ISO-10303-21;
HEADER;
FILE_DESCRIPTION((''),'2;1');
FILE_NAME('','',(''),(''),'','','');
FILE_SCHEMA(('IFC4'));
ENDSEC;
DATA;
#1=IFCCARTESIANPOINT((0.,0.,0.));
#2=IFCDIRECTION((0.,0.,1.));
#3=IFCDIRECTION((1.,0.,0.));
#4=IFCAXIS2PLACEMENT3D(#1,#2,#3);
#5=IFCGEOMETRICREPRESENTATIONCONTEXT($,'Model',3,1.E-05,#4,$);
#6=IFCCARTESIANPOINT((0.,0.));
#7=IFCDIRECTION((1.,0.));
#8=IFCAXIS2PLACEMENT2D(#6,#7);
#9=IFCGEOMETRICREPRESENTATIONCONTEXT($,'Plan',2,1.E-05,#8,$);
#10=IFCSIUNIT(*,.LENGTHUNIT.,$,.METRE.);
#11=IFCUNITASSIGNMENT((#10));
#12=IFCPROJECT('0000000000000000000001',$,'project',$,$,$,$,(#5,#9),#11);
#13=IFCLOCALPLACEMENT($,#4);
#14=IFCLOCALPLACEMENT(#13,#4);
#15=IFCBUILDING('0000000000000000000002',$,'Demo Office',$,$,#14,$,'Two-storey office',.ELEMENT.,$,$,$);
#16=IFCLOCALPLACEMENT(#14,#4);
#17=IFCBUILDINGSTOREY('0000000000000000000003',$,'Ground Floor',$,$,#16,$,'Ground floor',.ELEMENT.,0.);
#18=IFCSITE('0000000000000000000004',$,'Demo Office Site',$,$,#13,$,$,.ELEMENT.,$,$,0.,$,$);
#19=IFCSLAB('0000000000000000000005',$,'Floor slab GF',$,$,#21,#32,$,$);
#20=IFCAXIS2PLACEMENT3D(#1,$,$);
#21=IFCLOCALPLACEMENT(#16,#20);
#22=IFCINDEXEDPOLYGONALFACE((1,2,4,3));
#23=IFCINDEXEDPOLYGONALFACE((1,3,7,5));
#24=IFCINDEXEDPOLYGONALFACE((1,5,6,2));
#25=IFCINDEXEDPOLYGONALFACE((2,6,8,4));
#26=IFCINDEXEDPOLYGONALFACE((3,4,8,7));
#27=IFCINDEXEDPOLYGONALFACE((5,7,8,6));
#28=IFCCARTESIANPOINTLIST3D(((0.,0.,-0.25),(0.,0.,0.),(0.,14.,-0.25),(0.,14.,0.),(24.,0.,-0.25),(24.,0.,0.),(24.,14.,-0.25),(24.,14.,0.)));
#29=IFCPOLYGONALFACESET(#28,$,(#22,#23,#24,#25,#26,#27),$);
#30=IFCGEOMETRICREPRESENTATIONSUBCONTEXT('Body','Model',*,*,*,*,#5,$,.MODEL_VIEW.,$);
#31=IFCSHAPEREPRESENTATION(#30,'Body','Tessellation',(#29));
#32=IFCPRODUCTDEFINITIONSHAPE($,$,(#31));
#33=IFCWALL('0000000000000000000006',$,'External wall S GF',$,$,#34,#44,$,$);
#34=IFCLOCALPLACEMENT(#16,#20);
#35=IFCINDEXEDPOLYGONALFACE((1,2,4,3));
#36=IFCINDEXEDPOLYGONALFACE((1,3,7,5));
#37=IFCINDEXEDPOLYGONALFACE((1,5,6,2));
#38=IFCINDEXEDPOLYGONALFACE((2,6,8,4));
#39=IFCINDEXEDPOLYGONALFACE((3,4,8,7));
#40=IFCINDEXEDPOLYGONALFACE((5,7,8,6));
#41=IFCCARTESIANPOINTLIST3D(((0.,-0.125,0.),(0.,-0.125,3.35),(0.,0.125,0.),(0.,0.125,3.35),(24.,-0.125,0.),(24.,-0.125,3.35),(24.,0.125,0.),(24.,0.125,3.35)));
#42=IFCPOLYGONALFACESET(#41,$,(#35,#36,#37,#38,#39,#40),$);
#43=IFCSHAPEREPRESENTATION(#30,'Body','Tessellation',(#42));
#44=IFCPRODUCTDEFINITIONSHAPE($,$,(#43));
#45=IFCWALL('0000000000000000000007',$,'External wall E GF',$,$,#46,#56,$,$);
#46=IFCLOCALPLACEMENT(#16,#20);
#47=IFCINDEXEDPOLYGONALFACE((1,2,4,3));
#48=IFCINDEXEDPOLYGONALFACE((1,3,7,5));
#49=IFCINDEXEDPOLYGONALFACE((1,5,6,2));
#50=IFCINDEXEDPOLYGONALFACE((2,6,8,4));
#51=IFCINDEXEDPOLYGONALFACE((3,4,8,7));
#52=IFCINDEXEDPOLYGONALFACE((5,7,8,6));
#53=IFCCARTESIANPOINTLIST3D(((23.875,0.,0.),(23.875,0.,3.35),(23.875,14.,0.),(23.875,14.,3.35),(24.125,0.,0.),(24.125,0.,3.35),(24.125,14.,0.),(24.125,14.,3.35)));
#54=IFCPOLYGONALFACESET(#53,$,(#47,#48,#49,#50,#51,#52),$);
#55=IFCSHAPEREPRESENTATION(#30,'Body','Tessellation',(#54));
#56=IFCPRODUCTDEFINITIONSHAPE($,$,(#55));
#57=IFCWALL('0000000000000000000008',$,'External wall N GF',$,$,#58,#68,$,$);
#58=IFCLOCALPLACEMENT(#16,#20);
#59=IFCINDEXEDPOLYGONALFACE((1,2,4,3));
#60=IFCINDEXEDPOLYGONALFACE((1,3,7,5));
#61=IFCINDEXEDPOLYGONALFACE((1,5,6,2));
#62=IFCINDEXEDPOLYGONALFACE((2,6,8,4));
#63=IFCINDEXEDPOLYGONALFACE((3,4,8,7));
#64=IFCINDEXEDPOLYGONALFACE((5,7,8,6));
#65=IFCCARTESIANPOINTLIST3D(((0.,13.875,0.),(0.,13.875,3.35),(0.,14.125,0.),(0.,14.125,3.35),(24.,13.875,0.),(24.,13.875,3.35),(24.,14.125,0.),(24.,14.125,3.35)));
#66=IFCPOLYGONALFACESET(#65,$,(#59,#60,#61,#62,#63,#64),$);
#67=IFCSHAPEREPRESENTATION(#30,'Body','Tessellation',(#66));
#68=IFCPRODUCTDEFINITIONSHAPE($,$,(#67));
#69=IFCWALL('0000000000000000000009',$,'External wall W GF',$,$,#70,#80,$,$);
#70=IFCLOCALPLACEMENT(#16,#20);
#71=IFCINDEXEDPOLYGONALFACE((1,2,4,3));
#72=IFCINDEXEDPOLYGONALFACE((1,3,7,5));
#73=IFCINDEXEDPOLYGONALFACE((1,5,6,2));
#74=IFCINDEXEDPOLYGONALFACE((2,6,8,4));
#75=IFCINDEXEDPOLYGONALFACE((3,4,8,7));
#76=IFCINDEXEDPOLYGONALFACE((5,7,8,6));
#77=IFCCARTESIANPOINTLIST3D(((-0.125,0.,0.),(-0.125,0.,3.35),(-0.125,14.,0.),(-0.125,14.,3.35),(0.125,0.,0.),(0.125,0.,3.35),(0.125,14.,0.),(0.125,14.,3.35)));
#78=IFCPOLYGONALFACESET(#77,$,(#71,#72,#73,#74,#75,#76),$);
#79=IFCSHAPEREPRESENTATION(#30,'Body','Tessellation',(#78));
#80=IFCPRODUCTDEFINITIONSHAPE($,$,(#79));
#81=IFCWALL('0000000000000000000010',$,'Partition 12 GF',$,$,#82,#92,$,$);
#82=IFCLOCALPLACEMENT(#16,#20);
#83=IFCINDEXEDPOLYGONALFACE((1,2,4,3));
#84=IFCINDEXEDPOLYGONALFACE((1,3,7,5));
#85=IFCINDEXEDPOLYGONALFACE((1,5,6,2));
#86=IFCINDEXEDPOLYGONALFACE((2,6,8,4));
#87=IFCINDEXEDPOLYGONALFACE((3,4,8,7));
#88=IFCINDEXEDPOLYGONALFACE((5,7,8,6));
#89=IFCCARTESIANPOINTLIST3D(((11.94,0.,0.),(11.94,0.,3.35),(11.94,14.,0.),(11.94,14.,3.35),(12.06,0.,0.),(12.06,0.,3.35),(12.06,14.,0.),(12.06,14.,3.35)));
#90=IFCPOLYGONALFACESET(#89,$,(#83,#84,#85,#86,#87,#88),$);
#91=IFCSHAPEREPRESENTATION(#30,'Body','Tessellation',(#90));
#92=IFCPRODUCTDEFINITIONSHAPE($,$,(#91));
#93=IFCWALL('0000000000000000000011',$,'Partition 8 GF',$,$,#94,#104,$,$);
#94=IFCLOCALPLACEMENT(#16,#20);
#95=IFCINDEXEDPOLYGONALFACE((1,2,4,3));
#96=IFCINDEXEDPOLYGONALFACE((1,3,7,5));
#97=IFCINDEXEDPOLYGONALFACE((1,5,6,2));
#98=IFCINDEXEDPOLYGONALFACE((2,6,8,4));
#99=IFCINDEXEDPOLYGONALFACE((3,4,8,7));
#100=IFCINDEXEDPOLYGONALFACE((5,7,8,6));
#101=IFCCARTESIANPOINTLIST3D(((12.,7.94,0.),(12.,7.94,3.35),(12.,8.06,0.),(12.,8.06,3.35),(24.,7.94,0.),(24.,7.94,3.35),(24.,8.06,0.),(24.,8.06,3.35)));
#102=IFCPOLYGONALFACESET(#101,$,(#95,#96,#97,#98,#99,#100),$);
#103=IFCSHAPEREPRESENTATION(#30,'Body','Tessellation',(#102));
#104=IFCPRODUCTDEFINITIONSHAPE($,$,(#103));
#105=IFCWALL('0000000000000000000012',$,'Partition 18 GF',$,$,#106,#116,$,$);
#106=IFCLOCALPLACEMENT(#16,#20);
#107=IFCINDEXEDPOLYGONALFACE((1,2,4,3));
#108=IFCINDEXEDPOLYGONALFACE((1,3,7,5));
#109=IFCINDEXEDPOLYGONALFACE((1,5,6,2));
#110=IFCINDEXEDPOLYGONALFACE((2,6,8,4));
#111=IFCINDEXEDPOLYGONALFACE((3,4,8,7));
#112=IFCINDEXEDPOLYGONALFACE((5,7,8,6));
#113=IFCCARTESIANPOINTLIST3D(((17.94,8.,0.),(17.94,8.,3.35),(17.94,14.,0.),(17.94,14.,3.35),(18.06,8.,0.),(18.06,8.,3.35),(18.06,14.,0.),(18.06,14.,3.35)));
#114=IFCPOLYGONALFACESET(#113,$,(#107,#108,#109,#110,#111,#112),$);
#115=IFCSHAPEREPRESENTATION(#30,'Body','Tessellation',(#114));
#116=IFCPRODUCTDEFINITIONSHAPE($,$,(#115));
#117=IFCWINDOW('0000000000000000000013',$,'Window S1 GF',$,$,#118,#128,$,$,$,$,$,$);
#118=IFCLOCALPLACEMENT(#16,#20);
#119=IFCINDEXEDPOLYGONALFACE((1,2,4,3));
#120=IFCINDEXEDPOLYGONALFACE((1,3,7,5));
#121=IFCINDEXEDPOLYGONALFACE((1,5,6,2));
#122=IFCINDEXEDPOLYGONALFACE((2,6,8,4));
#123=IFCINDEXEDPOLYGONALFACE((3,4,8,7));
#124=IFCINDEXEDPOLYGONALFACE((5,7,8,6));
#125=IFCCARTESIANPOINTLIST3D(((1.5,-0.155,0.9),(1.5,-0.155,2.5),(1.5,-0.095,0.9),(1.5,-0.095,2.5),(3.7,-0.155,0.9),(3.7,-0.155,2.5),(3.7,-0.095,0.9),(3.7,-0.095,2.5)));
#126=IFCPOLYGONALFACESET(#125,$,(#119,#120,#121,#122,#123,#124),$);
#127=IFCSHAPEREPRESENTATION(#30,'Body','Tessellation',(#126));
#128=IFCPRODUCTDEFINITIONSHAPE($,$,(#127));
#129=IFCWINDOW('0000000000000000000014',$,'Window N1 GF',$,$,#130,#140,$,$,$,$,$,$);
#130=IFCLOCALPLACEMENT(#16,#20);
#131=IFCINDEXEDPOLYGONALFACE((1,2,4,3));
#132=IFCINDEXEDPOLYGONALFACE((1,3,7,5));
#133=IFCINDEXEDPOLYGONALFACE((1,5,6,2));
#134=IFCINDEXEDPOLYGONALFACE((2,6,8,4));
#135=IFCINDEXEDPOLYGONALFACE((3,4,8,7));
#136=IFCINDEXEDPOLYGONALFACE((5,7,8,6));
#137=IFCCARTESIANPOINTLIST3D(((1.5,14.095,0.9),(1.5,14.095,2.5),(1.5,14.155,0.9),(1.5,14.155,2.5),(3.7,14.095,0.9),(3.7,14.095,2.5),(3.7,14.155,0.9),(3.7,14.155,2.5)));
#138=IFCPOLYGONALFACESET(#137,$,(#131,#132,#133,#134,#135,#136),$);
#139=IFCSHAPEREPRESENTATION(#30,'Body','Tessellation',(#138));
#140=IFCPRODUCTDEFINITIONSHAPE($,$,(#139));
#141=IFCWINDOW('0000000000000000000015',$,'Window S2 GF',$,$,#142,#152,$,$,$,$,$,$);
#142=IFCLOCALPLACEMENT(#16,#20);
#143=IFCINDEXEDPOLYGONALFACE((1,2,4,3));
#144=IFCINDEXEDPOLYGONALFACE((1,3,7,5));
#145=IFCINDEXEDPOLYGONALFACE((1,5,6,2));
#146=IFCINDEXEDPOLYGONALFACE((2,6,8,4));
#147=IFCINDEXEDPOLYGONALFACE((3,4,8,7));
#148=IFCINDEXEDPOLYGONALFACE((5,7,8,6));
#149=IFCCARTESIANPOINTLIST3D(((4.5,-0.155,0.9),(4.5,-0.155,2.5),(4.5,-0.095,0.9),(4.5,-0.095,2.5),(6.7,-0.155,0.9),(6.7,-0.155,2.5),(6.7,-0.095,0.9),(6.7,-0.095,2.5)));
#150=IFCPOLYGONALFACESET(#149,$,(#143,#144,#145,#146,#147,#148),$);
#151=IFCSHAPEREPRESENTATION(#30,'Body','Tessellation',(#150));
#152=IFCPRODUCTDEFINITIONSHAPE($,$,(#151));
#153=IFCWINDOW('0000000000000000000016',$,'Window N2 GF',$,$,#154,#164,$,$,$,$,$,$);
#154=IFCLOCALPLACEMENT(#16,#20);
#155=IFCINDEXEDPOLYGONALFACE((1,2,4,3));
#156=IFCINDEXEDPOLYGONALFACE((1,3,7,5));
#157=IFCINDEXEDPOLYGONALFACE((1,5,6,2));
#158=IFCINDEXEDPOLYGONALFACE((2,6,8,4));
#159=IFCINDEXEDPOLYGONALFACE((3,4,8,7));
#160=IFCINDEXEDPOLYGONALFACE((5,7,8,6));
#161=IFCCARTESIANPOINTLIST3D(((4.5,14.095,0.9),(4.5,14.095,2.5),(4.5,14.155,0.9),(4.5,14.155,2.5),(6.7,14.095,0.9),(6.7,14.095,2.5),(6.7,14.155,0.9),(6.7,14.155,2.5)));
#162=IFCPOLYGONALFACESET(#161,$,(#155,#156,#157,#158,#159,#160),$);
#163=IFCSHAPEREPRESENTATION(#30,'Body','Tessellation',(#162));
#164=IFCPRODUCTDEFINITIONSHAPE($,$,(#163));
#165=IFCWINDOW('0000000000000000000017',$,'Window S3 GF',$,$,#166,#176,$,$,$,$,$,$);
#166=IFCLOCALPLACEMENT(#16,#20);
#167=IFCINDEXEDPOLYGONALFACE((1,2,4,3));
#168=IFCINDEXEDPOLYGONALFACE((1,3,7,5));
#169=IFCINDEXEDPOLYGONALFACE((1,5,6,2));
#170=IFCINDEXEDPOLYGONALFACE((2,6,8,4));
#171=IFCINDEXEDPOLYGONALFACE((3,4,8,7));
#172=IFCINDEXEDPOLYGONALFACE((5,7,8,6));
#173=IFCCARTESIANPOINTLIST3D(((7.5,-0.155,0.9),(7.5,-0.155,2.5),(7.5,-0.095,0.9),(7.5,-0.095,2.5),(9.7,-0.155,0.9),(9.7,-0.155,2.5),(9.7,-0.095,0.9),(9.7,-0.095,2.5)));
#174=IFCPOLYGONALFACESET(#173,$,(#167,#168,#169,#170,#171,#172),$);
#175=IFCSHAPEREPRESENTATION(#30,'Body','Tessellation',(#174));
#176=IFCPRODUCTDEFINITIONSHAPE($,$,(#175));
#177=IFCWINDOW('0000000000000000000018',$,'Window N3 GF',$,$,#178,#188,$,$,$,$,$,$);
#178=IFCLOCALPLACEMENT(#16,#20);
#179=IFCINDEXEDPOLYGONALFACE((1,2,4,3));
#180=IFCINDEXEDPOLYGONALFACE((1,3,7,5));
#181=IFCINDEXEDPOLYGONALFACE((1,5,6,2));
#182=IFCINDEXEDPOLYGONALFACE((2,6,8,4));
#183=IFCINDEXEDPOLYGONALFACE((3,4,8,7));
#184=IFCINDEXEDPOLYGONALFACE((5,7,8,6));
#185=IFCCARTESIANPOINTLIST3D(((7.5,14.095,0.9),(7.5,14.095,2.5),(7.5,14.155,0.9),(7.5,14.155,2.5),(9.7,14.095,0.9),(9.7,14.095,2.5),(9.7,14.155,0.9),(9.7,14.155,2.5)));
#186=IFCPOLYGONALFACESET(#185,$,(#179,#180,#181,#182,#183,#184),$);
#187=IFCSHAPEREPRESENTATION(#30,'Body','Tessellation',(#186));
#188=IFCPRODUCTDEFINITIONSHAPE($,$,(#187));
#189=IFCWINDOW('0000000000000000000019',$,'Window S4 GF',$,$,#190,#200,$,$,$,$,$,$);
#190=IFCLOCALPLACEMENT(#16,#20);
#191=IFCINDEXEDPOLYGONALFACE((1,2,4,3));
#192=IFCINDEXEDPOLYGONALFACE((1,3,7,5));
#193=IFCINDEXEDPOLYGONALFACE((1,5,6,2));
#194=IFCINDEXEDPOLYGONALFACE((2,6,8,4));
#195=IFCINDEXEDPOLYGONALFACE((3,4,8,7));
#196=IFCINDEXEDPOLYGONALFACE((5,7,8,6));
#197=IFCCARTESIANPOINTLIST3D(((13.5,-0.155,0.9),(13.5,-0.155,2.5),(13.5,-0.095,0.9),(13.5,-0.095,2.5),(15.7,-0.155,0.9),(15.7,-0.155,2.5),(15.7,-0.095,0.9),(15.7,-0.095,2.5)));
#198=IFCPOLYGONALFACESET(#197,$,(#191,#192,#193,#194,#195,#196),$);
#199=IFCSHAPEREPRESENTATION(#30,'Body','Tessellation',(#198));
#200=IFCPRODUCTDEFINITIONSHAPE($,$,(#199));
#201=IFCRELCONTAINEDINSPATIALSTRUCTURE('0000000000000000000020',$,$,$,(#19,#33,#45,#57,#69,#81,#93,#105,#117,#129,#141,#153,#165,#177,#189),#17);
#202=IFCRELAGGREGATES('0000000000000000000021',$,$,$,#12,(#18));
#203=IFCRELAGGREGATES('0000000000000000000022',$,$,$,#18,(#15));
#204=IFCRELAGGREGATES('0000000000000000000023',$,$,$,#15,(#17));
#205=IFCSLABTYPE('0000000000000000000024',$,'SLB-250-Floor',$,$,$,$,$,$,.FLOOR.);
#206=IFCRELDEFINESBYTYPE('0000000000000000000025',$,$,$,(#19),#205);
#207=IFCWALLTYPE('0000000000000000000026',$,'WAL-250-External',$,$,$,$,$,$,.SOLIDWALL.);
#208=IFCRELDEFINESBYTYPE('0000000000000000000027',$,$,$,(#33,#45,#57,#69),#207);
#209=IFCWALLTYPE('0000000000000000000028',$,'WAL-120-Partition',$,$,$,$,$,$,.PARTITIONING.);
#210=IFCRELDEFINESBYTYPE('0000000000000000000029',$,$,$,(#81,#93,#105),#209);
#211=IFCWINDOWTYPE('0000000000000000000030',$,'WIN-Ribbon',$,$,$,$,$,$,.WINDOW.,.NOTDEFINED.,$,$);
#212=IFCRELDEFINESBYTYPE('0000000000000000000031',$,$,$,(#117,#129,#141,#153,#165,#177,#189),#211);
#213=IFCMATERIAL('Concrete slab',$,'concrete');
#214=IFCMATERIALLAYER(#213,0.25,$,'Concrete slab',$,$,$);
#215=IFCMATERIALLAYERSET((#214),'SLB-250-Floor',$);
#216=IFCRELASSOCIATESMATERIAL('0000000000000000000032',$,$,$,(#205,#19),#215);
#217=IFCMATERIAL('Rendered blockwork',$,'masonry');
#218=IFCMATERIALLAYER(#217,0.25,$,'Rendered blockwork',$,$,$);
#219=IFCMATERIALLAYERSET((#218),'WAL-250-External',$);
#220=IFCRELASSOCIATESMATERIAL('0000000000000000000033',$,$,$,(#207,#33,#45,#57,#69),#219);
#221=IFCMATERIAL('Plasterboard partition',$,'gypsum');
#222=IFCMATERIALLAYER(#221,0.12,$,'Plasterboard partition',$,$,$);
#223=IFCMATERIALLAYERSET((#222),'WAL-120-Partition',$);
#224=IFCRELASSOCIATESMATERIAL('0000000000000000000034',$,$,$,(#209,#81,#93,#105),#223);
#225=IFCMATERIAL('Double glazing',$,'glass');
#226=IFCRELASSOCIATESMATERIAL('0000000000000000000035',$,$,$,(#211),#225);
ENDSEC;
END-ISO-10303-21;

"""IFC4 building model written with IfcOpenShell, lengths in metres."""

from ifc_helpers import new_model, si_unit, frame, origin_with_axes, origin_2d_with_axis, place, context, subcontext, project, spatial, line, indexed_curve, outline, extrude, material, layer, layer_set, layer_usage, type_object, element, save


model = new_model("IFC4")

# Units and contexts
model_context = context("Model", 3, precision=1e-05, world=origin_with_axes())
plan_context = context("Plan", 2, precision=1e-05, world=origin_2d_with_axis())
body_context = subcontext(model_context, "Body", "Model", "MODEL_VIEW")
ifc_project = project(units=[si_unit("LENGTHUNIT", "METRE")], contexts=[model_context, plan_context])

# Site, building, storey
site_placement = place(None, origin_with_axes())
site = spatial("IfcSite", under=ifc_project, at=site_placement, Name="Demo Office Site", CompositionType="ELEMENT", RefElevation=0.0)
building_placement = place(site_placement, origin_with_axes())
building = spatial("IfcBuilding", under=site, at=building_placement, Name="Demo Office", LongName="Two-storey office", CompositionType="ELEMENT")
storey_placement = place(building_placement, origin_with_axes())
storey = spatial("IfcBuildingStorey", under=building, at=storey_placement, Name="Ground Floor", LongName="Ground floor", CompositionType="ELEMENT", Elevation=0.0)

# Slab
ifc_material_1 = material(Name="Concrete slab", Category="concrete")
ifc_layer_1 = layer(ifc_material_1, 0.25, Name="Concrete slab")
ifc_layer_set_1 = layer_set([ifc_layer_1], Name="SLB-250-Floor")
ifc_layer_usage_1 = layer_usage(ifc_layer_set_1, "AXIS3", "POSITIVE", 0.0)
slab_type = type_object("IfcSlabType", Name="SLB-250-Floor", PredefinedType="FLOOR", material=ifc_layer_set_1)
slab_placement = place(storey_placement, frame((0.0, 0.0, -0.25), z_axis=(0.0, 0.0, 1.0), x_axis=(1.0, 0.0, 0.0)))
element("IfcSlab", 1, at=slab_placement, inside=storey, type_object=slab_type, material=ifc_layer_usage_1, Name="Floor slab GF", context=body_context, shape_type="SweptSolid", body=[
    extrude(outline(indexed_curve([(0.0, 0.0), (24.0, 0.0), (24.0, 14.0), (0.0, 14.0)], segments=[line(1, 2, 3, 4, 1)])), origin_with_axes(), (0.0, 0.0, 1.0), 0.25),
])

# Walls
ifc_material_2 = material(Name="Rendered blockwork", Category="masonry")
ifc_layer_2 = layer(ifc_material_2, 0.25, Name="Rendered blockwork")
ifc_layer_set_2 = layer_set([ifc_layer_2], Name="WAL-250-External")
ifc_layer_usage_2 = layer_usage(ifc_layer_set_2, "AXIS2", "POSITIVE", 0.0)
wall_type_1 = type_object("IfcWallType", Name="WAL-250-External", PredefinedType="SOLIDWALL", material=ifc_layer_set_2)
wall_1_placement = place(storey_placement, origin_with_axes())
element("IfcWall", 2, at=wall_1_placement, inside=storey, type_object=wall_type_1, material=ifc_layer_usage_2, Name="External wall S GF", context=body_context, shape_type="SweptSolid", body=[
    extrude(outline(indexed_curve([(0.0, 0.0), (0.0, 0.25), (24.0, 0.25), (24.0, 0.0), (0.0, 0.0)], self_intersect=False)), frame((0.0, -0.125, 0.0), z_axis=(0.0, 0.0, 1.0), x_axis=(1.0, 0.0, 0.0)), (0.0, 0.0, 1.0), 3.35),
])
ifc_layer_usage_3 = layer_usage(ifc_layer_set_2, "AXIS2", "POSITIVE", 0.0)
wall_2_placement = place(storey_placement, frame((24.0, 0.0, 0.0), z_axis=(0.0, 0.0, 1.0), x_axis=(0.0, 1.0, 0.0)))
element("IfcWall", 3, at=wall_2_placement, inside=storey, type_object=wall_type_1, material=ifc_layer_usage_3, Name="External wall E GF", context=body_context, shape_type="SweptSolid", body=[
    extrude(outline(indexed_curve([(0.0, 0.0), (0.0, 0.25), (14.0, 0.25), (14.0, 0.0), (0.0, 0.0)], self_intersect=False)), frame((0.0, -0.125, 0.0), z_axis=(0.0, 0.0, 1.0), x_axis=(1.0, 0.0, 0.0)), (0.0, 0.0, 1.0), 3.35),
])
ifc_layer_usage_4 = layer_usage(ifc_layer_set_2, "AXIS2", "POSITIVE", 0.0)
wall_3_placement = place(storey_placement, frame((24.0, 14.0, 0.0), z_axis=(0.0, 0.0, 1.0), x_axis=(-1.0, 0.0, 0.0)))
element("IfcWall", 4, at=wall_3_placement, inside=storey, type_object=wall_type_1, material=ifc_layer_usage_4, Name="External wall N GF", context=body_context, shape_type="SweptSolid", body=[
    extrude(outline(indexed_curve([(0.0, 0.0), (0.0, 0.25), (24.0, 0.25), (24.0, 0.0), (0.0, 0.0)], self_intersect=False)), frame((0.0, -0.125, 0.0), z_axis=(0.0, 0.0, 1.0), x_axis=(1.0, 0.0, 0.0)), (0.0, 0.0, 1.0), 3.35),
])
ifc_layer_usage_5 = layer_usage(ifc_layer_set_2, "AXIS2", "POSITIVE", 0.0)
wall_4_placement = place(storey_placement, frame((0.0, 14.0, 0.0), z_axis=(0.0, 0.0, 1.0), x_axis=(0.0, -1.0, 0.0)))
element("IfcWall", 5, at=wall_4_placement, inside=storey, type_object=wall_type_1, material=ifc_layer_usage_5, Name="External wall W GF", context=body_context, shape_type="SweptSolid", body=[
    extrude(outline(indexed_curve([(0.0, 0.0), (0.0, 0.25), (14.0, 0.25), (14.0, 0.0), (0.0, 0.0)], self_intersect=False)), frame((0.0, -0.125, 0.0), z_axis=(0.0, 0.0, 1.0), x_axis=(1.0, 0.0, 0.0)), (0.0, 0.0, 1.0), 3.35),
])
ifc_material_3 = material(Name="Plasterboard partition", Category="gypsum")
ifc_layer_3 = layer(ifc_material_3, 0.12, Name="Plasterboard partition")
ifc_layer_set_3 = layer_set([ifc_layer_3], Name="WAL-120-Partition")
ifc_layer_usage_6 = layer_usage(ifc_layer_set_3, "AXIS2", "POSITIVE", 0.0)
wall_type_2 = type_object("IfcWallType", Name="WAL-120-Partition", PredefinedType="PARTITIONING", material=ifc_layer_set_3)
wall_5_placement = place(storey_placement, frame((12.0, 0.0, 0.0), z_axis=(0.0, 0.0, 1.0), x_axis=(0.0, 1.0, 0.0)))
element("IfcWall", 6, at=wall_5_placement, inside=storey, type_object=wall_type_2, material=ifc_layer_usage_6, Name="Partition 12 GF", context=body_context, shape_type="SweptSolid", body=[
    extrude(outline(indexed_curve([(0.0, 0.0), (0.0, 0.12), (14.0, 0.12), (14.0, 0.0), (0.0, 0.0)], self_intersect=False)), frame((0.0, -0.06, 0.0), z_axis=(0.0, 0.0, 1.0), x_axis=(1.0, 0.0, 0.0)), (0.0, 0.0, 1.0), 3.35),
])
ifc_layer_usage_7 = layer_usage(ifc_layer_set_3, "AXIS2", "POSITIVE", 0.0)
wall_6_placement = place(storey_placement, frame((12.0, 8.0, 0.0), z_axis=(0.0, 0.0, 1.0), x_axis=(1.0, 0.0, 0.0)))
element("IfcWall", 7, at=wall_6_placement, inside=storey, type_object=wall_type_2, material=ifc_layer_usage_7, Name="Partition 8 GF", context=body_context, shape_type="SweptSolid", body=[
    extrude(outline(indexed_curve([(0.0, 0.0), (0.0, 0.12), (12.0, 0.12), (12.0, 0.0), (0.0, 0.0)], self_intersect=False)), frame((0.0, -0.06, 0.0), z_axis=(0.0, 0.0, 1.0), x_axis=(1.0, 0.0, 0.0)), (0.0, 0.0, 1.0), 3.35),
])
ifc_layer_usage_8 = layer_usage(ifc_layer_set_3, "AXIS2", "POSITIVE", 0.0)
wall_7_placement = place(storey_placement, frame((18.0, 8.0, 0.0), z_axis=(0.0, 0.0, 1.0), x_axis=(0.0, 1.0, 0.0)))
element("IfcWall", 8, at=wall_7_placement, inside=storey, type_object=wall_type_2, material=ifc_layer_usage_8, Name="Partition 18 GF", context=body_context, shape_type="SweptSolid", body=[
    extrude(outline(indexed_curve([(0.0, 0.0), (0.0, 0.12), (6.0, 0.12), (6.0, 0.0), (0.0, 0.0)], self_intersect=False)), frame((0.0, -0.06, 0.0), z_axis=(0.0, 0.0, 1.0), x_axis=(1.0, 0.0, 0.0)), (0.0, 0.0, 1.0), 3.35),
])

# Windows
ifc_material_4 = material(Name="Double glazing", Category="glass")
window_type = type_object("IfcWindowType", Name="WIN-Ribbon", PartitioningType="NOTDEFINED", PredefinedType="WINDOW", material=ifc_material_4)
for number, where, z_axis, x_axis, name in (
    (9, (1.5, -0.155, 0.9), (0.0, 0.0, 1.0), (1.0, 0.0, 0.0), "Window S1 GF"),
    (10, (1.5, 14.095, 0.9), (0.0, 0.0, 1.0), (1.0, 0.0, 0.0), "Window N1 GF"),
    (11, (4.5, -0.155, 0.9), (0.0, 0.0, 1.0), (1.0, 0.0, 0.0), "Window S2 GF"),
    (12, (4.5, 14.095, 0.9), (0.0, 0.0, 1.0), (1.0, 0.0, 0.0), "Window N2 GF"),
    (13, (7.5, -0.155, 0.9), (0.0, 0.0, 1.0), (1.0, 0.0, 0.0), "Window S3 GF"),
    (14, (7.5, 14.095, 0.9), (0.0, 0.0, 1.0), (1.0, 0.0, 0.0), "Window N3 GF"),
    (15, (13.5, -0.155, 0.9), (0.0, 0.0, 1.0), (1.0, 0.0, 0.0), "Window S4 GF"),
):
    element("IfcWindow", number, at=place(storey_placement, frame(where, z_axis=z_axis, x_axis=x_axis)), inside=storey, type_object=window_type, Name=name, context=body_context, shape_type="SweptSolid", body=[
        extrude(outline(indexed_curve([(0.0, 0.0), (2.2, 0.0), (2.2, 0.06), (0.0, 0.06)], segments=[line(1, 2, 3, 4, 1)])), origin_with_axes(), (0.0, 0.0, 1.0), 1.6),
    ])

save(model, "model.ifc")
